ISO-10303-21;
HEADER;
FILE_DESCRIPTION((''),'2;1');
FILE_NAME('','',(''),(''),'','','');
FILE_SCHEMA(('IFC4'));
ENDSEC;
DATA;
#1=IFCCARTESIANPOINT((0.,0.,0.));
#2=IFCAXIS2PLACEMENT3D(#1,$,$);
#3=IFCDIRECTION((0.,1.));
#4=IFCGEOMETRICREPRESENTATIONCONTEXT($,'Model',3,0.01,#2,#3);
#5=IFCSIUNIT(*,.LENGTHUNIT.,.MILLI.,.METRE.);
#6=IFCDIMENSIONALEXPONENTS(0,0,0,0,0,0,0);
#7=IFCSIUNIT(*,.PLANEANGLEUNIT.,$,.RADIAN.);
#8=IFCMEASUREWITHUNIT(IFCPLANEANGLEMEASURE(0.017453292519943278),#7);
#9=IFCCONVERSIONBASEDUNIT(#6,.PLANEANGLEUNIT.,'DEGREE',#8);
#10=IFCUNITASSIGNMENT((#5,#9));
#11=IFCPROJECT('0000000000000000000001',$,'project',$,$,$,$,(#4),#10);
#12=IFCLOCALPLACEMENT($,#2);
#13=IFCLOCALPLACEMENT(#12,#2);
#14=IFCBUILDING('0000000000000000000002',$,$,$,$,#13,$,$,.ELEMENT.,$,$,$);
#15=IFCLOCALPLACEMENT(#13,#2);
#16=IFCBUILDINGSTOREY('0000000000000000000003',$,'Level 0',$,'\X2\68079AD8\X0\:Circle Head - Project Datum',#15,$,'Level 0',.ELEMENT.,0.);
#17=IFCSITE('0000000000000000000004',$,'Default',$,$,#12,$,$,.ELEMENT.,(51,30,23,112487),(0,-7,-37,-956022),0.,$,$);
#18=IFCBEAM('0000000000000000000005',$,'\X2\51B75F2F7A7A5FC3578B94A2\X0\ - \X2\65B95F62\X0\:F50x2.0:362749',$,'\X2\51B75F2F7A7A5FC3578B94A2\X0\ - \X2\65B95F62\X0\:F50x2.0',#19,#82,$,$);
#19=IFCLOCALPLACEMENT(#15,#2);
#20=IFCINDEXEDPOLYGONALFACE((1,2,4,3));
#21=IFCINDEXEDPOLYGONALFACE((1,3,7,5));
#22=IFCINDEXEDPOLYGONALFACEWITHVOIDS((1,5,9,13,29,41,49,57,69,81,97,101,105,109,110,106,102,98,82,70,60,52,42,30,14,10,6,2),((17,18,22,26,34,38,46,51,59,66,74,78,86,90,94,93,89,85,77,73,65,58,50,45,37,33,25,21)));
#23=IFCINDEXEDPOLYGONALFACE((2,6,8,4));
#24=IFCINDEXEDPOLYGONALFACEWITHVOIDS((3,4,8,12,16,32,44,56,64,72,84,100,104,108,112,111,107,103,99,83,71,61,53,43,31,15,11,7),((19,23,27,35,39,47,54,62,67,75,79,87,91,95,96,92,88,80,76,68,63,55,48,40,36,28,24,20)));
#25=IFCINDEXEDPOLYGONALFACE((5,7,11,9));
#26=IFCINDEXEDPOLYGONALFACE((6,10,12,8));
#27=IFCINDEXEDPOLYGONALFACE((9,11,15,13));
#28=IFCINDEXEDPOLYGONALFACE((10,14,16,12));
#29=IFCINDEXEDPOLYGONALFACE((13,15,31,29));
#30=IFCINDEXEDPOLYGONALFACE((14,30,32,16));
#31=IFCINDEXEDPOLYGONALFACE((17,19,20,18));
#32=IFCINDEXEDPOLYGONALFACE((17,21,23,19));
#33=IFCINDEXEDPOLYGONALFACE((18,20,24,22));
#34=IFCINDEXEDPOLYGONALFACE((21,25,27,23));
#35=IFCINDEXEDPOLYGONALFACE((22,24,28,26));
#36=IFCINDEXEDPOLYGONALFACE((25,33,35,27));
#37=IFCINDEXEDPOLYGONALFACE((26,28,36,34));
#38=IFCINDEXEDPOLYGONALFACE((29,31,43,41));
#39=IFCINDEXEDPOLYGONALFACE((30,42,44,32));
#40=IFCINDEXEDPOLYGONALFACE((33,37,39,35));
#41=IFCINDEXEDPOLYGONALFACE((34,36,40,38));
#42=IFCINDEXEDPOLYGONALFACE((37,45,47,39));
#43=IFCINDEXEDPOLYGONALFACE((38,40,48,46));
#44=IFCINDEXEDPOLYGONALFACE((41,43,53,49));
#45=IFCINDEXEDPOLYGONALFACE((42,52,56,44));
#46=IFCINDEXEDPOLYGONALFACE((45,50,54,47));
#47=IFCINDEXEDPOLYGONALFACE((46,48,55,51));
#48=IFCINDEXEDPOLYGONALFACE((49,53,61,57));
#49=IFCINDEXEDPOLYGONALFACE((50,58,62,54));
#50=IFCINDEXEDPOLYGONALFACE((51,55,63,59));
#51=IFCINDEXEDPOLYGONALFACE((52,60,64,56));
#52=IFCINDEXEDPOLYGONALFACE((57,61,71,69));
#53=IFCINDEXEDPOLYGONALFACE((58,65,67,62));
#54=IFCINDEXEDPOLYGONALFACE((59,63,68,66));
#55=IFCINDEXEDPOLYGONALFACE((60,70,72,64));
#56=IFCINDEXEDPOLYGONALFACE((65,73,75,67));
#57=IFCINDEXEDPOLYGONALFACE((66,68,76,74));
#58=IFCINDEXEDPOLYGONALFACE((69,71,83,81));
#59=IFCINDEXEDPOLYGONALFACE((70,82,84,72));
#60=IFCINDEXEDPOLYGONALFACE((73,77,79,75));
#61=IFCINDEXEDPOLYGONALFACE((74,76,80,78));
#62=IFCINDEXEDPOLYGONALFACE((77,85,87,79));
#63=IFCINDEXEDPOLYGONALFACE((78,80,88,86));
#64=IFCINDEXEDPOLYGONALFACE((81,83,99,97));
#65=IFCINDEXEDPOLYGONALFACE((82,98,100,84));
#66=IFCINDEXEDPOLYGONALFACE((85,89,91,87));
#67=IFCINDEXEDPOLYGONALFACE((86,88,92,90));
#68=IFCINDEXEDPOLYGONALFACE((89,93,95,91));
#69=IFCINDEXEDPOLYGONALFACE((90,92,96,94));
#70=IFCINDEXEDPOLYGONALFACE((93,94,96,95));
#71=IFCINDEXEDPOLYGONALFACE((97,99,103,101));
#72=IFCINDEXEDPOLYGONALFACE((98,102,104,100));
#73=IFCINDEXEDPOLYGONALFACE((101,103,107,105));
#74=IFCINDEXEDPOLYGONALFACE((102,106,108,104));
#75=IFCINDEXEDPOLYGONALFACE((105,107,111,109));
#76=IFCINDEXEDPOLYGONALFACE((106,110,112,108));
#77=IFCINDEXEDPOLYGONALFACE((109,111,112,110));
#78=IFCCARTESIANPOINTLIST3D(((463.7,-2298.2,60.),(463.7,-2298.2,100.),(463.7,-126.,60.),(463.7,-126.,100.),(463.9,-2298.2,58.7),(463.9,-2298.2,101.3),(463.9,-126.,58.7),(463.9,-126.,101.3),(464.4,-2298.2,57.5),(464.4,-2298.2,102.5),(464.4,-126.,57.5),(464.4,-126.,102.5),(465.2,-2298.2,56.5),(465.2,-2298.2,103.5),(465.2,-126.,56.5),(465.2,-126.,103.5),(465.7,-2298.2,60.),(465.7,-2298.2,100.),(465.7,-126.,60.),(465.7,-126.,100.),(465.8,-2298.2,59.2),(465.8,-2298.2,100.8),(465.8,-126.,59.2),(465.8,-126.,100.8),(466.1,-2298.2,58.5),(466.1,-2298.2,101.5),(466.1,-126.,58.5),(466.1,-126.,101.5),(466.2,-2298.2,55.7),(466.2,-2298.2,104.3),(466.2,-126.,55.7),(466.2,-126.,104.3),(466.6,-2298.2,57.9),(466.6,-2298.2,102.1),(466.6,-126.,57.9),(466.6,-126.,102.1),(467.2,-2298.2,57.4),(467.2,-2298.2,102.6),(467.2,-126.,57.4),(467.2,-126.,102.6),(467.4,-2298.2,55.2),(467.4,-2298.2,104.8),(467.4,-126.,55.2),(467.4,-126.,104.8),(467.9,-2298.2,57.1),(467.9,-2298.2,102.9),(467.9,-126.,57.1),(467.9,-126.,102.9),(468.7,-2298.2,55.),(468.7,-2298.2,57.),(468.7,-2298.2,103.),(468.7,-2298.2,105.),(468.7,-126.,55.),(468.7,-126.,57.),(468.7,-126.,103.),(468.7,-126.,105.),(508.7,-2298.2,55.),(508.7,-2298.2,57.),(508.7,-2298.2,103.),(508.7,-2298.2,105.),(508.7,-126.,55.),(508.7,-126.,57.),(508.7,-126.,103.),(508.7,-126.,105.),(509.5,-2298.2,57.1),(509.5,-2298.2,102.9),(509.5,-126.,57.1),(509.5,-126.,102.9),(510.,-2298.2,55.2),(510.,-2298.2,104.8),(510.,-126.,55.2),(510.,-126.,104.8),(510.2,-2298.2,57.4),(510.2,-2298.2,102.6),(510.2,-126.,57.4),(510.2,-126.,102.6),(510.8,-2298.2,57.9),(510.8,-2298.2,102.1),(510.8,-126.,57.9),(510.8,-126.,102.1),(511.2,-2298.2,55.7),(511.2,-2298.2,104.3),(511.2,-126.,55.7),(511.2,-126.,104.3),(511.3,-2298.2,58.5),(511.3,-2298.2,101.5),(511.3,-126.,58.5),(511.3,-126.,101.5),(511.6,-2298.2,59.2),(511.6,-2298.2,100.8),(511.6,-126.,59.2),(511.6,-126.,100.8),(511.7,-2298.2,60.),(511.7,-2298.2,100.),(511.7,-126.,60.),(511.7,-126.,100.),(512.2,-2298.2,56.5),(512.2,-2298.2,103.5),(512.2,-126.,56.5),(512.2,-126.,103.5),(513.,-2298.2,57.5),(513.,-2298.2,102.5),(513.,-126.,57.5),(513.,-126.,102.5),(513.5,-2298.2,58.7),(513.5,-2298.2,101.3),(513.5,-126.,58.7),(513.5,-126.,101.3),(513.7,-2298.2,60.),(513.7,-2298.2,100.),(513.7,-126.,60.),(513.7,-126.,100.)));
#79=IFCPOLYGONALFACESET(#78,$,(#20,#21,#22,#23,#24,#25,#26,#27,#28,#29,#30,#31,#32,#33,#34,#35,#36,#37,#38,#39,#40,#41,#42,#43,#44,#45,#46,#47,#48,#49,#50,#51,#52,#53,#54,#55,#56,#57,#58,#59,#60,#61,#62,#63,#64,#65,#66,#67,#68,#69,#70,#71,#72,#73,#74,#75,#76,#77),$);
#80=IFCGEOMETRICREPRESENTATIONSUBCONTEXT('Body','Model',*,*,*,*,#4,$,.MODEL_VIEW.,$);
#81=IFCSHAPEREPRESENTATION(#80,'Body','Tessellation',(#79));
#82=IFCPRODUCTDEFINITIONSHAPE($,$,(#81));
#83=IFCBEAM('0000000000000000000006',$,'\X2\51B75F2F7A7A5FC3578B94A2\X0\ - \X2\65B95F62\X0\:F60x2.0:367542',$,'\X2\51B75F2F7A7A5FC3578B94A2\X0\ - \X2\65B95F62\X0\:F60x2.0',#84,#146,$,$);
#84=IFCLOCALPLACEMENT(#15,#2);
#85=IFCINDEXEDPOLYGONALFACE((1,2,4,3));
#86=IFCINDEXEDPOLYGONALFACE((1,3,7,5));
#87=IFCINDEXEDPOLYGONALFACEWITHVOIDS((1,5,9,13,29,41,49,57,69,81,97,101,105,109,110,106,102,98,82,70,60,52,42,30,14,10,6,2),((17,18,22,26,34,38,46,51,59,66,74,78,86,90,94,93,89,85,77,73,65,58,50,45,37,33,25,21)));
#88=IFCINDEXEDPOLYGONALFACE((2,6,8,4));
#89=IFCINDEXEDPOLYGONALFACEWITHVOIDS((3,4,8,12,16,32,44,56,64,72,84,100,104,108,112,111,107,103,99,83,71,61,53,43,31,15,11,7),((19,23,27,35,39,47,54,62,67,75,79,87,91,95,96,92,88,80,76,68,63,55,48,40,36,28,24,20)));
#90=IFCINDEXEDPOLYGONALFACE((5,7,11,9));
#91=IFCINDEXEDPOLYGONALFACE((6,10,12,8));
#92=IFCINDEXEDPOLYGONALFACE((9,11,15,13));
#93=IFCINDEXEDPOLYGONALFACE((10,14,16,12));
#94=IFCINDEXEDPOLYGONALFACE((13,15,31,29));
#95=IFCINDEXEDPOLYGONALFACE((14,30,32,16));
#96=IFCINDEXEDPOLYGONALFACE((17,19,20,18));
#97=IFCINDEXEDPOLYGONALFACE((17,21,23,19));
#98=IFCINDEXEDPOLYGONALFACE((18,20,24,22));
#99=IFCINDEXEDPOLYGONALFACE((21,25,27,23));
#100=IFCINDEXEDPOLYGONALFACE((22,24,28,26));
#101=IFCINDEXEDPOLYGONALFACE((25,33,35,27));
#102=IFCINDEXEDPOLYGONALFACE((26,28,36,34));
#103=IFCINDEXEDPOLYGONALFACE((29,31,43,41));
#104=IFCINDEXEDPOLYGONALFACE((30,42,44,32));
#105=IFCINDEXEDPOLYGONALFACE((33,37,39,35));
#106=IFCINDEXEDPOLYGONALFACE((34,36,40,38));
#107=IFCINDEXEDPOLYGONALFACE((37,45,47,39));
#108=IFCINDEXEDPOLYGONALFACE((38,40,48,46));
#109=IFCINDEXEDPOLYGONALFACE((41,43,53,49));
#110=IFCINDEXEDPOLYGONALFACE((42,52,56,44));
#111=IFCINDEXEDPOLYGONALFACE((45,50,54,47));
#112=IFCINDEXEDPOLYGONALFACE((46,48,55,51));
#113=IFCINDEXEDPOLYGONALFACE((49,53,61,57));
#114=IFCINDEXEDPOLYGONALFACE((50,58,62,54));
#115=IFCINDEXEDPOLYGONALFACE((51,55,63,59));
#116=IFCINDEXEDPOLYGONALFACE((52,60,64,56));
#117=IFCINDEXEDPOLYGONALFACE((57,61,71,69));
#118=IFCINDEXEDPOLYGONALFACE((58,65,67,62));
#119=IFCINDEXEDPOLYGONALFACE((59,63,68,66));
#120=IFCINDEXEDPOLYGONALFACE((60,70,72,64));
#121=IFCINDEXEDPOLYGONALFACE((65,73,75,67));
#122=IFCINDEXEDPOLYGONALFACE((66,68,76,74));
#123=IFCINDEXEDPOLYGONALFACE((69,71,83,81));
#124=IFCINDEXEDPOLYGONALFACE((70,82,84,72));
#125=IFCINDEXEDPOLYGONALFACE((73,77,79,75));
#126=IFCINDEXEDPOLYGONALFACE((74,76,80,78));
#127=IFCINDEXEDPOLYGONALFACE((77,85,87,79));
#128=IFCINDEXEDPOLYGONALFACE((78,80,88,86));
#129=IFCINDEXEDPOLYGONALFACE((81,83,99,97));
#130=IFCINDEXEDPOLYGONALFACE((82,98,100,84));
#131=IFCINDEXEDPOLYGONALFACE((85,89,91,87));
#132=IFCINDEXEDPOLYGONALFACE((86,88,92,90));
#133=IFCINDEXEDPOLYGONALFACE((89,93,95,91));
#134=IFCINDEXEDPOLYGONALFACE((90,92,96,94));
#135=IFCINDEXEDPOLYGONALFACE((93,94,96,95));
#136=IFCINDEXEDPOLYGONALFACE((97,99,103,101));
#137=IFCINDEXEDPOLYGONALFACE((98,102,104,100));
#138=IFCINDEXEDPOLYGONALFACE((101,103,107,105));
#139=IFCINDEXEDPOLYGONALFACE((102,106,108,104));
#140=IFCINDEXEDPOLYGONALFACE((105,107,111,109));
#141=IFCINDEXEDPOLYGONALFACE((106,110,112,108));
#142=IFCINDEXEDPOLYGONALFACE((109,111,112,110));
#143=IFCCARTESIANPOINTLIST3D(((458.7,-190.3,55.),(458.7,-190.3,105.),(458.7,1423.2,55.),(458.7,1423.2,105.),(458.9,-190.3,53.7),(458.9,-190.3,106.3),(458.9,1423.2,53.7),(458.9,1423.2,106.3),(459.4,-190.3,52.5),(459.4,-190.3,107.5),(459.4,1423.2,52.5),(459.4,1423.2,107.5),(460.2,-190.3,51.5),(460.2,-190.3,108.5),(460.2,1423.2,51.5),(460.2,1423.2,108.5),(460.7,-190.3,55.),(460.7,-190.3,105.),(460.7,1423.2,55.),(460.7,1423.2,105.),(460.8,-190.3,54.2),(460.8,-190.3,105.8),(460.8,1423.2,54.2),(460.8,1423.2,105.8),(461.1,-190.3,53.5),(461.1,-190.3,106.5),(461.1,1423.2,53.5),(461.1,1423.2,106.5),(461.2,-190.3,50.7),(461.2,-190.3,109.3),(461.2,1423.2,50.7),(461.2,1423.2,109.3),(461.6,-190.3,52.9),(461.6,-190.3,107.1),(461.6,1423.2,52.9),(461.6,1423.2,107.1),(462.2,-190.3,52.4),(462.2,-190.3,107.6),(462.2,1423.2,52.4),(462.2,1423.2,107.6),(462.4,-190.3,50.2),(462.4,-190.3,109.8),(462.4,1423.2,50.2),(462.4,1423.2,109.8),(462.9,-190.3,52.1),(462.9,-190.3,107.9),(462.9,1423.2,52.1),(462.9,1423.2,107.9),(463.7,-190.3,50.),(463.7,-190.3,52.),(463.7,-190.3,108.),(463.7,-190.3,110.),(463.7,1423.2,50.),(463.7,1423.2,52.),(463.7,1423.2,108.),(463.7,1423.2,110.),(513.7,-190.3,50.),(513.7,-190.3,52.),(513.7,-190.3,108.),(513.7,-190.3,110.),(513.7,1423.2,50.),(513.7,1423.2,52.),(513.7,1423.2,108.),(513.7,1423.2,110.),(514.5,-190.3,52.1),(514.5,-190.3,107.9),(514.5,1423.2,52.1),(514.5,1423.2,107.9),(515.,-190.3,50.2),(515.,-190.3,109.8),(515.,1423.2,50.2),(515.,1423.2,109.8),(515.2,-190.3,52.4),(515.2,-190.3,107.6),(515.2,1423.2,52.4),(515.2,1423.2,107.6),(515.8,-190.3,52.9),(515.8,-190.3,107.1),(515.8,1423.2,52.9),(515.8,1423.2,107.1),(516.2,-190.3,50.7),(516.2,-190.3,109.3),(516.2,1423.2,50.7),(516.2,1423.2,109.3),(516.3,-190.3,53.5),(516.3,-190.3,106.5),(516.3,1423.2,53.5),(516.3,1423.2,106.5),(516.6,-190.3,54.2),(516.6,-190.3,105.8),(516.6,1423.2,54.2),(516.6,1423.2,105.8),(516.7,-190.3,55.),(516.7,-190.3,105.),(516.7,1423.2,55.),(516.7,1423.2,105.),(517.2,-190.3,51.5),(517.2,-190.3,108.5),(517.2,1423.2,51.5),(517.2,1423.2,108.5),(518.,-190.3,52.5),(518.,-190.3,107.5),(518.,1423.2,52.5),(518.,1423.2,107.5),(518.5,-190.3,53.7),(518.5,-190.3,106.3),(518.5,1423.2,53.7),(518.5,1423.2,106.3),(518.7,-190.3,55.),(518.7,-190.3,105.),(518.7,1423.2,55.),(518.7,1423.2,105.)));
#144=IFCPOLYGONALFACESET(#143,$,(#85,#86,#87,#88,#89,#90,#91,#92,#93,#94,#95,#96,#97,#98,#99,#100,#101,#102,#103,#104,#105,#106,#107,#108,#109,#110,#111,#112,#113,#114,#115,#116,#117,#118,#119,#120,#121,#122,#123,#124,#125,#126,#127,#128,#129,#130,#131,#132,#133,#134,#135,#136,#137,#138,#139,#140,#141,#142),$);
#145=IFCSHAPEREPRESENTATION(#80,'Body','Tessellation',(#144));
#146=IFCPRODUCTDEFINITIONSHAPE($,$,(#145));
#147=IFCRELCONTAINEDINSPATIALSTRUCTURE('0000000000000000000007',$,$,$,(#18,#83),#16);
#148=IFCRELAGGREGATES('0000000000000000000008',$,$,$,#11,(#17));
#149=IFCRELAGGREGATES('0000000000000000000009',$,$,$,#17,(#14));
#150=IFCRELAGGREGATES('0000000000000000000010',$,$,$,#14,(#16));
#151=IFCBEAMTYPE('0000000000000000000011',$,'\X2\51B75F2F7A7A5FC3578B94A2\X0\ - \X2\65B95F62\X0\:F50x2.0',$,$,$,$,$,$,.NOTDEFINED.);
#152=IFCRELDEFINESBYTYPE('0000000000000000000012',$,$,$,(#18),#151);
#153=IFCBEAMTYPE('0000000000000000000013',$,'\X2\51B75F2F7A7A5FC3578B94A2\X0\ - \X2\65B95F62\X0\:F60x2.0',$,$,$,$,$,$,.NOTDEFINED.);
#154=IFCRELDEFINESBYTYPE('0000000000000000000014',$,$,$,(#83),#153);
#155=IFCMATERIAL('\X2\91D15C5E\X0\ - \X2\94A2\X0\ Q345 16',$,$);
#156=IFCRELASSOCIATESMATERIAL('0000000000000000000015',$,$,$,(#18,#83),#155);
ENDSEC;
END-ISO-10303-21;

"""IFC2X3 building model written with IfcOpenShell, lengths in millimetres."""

from ifc_helpers import new_model, entity, si_unit, converted_unit, direction, frame, frame_2d, origin, place, context, subcontext, project, spatial, polyline, circle_curve, parameter, trimmed, segment, composite_curve, outline, extrude, material, type_object, element, save


model = new_model("IFC2X3")

# Units and contexts
model_context = context("Model", 3, precision=0.01, world=origin(), true_north=direction((0.0, 1.0)))
body_context = subcontext(model_context, "Body", "Model", "MODEL_VIEW")
ifc_project = project(units=[si_unit("LENGTHUNIT", "METRE", prefix="MILLI"), converted_unit("PLANEANGLEUNIT", "DEGREE", entity("IfcPlaneAngleMeasure", 0.017453292519943278), si_unit("PLANEANGLEUNIT", "RADIAN"), dimensions=[0, 0, 0, 0, 0, 0, 0])], contexts=[model_context])

# Site, building, storey
site_placement = place(None, origin())
site = spatial("IfcSite", under=ifc_project, at=site_placement, Name="Default", CompositionType="ELEMENT", RefLatitude=(51, 30, 23, 112487), RefLongitude=(0, -7, -37, -956022), RefElevation=0.0)
building_placement = place(site_placement, origin())
building = spatial("IfcBuilding", under=site, at=building_placement, CompositionType="ELEMENT")
storey_placement = place(building_placement, origin())
storey = spatial("IfcBuildingStorey", under=building, at=storey_placement, Name="Level 0", ObjectType="标高:Circle Head - Project Datum", LongName="Level 0", CompositionType="ELEMENT", Elevation=0.0)

# Beams
ifc_material_1 = material(Name="金属 - 钢 Q345 16")
beam_type_1 = type_object("IfcBeamType", Name="冷弯空心型钢 - 方形:F50x2.0", PredefinedType="NOTDEFINED")
beam_1_placement = place(storey_placement, frame((488.7, -390.5, 105.0), z_axis=(0.0, 0.0, 1.0), x_axis=(0.0, -1.0, 0.0)))
element("IfcBeam", 1, at=beam_1_placement, inside=storey, type_object=beam_type_1, material=ifc_material_1, Name="冷弯空心型钢 - 方形:F50x2.0:362749", ObjectType="冷弯空心型钢 - 方形:F50x2.0", context=body_context, shape_type="SweptSolid", body=[
    extrude(outline(composite_curve([segment(trimmed(circle_curve(frame_2d((-20.0, 20.0), x_axis=(1.0, 0.0)), 5.0), [parameter(90.0)], [parameter(180.0)], True, "PARAMETER"), True, "CONTINUOUS"), segment(polyline([(-25.0, 20.0), (-25.0, -20.0)]), True, "CONTINUOUS"), segment(trimmed(circle_curve(frame_2d((-20.0, -20.0), x_axis=(1.0, 0.0)), 5.0), [parameter(180.0)], [parameter(270.0)], True, "PARAMETER"), True, "CONTINUOUS"), segment(polyline([(-20.0, -25.0), (20.0, -25.0)]), True, "CONTINUOUS"), segment(trimmed(circle_curve(frame_2d((20.0, -20.0), x_axis=(1.0, 0.0)), 5.0), [parameter(270.0)], [parameter(0.0)], True, "PARAMETER"), True, "CONTINUOUS"), segment(polyline([(25.0, -20.0), (25.0, 20.0)]), True, "CONTINUOUS"), segment(trimmed(circle_curve(frame_2d((20.0, 20.0), x_axis=(1.0, 0.0)), 5.0), [parameter(0.0)], [parameter(90.0)], True, "PARAMETER"), True, "CONTINUOUS"), segment(polyline([(20.0, 25.0), (-20.0, 25.0)]), True, "CONTINUOUS")], self_intersect=False), holes=[composite_curve([segment(polyline([(-20.0, 23.0), (20.0, 23.0)]), True, "CONTINUOUS"), segment(trimmed(circle_curve(frame_2d((20.0, 20.0), x_axis=(1.0, 0.0)), 3.0), [parameter(360.0)], [parameter(90.0)], True, "PARAMETER"), False, "CONTINUOUS"), segment(polyline([(23.0, 20.0), (23.0, -20.0)]), True, "CONTINUOUS"), segment(trimmed(circle_curve(frame_2d((20.0, -20.0), x_axis=(1.0, 0.0)), 3.0), [parameter(270.0)], [parameter(360.0)], True, "PARAMETER"), False, "CONTINUOUS"), segment(polyline([(20.0, -23.0), (-20.0, -23.0)]), True, "CONTINUOUS"), segment(trimmed(circle_curve(frame_2d((-20.0, -20.0), x_axis=(1.0, 0.0)), 3.0), [parameter(180.0)], [parameter(270.0)], True, "PARAMETER"), False, "CONTINUOUS"), segment(polyline([(-23.0, -20.0), (-23.0, 20.0)]), True, "CONTINUOUS"), segment(trimmed(circle_curve(frame_2d((-20.0, 20.0), x_axis=(1.0, 0.0)), 3.0), [parameter(90.0)], [parameter(180.0)], True, "PARAMETER"), False, "CONTINUOUS")], self_intersect=False)]), frame((-264.5, 0.0, -25.0), z_axis=(1.0, 0.0, 0.0), x_axis=(0.0, 1.0, 0.0)), (0.0, 0.0, 1.0), 2172.2),
])
beam_type_2 = type_object("IfcBeamType", Name="冷弯空心型钢 - 方形:F60x2.0", PredefinedType="NOTDEFINED")
beam_2_placement = place(storey_placement, frame((488.7, 1388.1, 110.0), z_axis=(0.0, 0.0, 1.0), x_axis=(0.0, -1.0, 0.0)))
element("IfcBeam", 2, at=beam_2_placement, inside=storey, type_object=beam_type_2, material=ifc_material_1, Name="冷弯空心型钢 - 方形:F60x2.0:367542", ObjectType="冷弯空心型钢 - 方形:F60x2.0", context=body_context, shape_type="SweptSolid", body=[
    extrude(outline(composite_curve([segment(trimmed(circle_curve(frame_2d((-25.0, 25.0), x_axis=(1.0, 0.0)), 5.0), [parameter(90.0)], [parameter(180.0)], True, "PARAMETER"), True, "CONTINUOUS"), segment(polyline([(-30.0, 25.0), (-30.0, -25.0)]), True, "CONTINUOUS"), segment(trimmed(circle_curve(frame_2d((-25.0, -25.0), x_axis=(1.0, 0.0)), 5.0), [parameter(180.0)], [parameter(270.0)], True, "PARAMETER"), True, "CONTINUOUS"), segment(polyline([(-25.0, -30.0), (25.0, -30.0)]), True, "CONTINUOUS"), segment(trimmed(circle_curve(frame_2d((25.0, -25.0), x_axis=(1.0, 0.0)), 5.0), [parameter(270.0)], [parameter(0.0)], True, "PARAMETER"), True, "CONTINUOUS"), segment(polyline([(30.0, -25.0), (30.0, 25.0)]), True, "CONTINUOUS"), segment(trimmed(circle_curve(frame_2d((25.0, 25.0), x_axis=(1.0, 0.0)), 5.0), [parameter(0.0)], [parameter(90.0)], True, "PARAMETER"), True, "CONTINUOUS"), segment(polyline([(25.0, 30.0), (-25.0, 30.0)]), True, "CONTINUOUS")], self_intersect=False), holes=[composite_curve([segment(polyline([(-25.0, 28.0), (25.0, 28.0)]), True, "CONTINUOUS"), segment(trimmed(circle_curve(frame_2d((25.0, 25.0), x_axis=(1.0, 0.0)), 3.0), [parameter(0.0)], [parameter(90.0)], True, "PARAMETER"), False, "CONTINUOUS"), segment(polyline([(28.0, 25.0), (28.0, -25.0)]), True, "CONTINUOUS"), segment(trimmed(circle_curve(frame_2d((25.0, -25.0), x_axis=(1.0, 0.0)), 3.0), [parameter(270.0)], [parameter(360.0)], True, "PARAMETER"), False, "CONTINUOUS"), segment(polyline([(25.0, -28.0), (-25.0, -28.0)]), True, "CONTINUOUS"), segment(trimmed(circle_curve(frame_2d((-25.0, -25.0), x_axis=(1.0, 0.0)), 3.0), [parameter(180.0)], [parameter(270.0)], True, "PARAMETER"), False, "CONTINUOUS"), segment(polyline([(-28.0, -25.0), (-28.0, 25.0)]), True, "CONTINUOUS"), segment(trimmed(circle_curve(frame_2d((-25.0, 25.0), x_axis=(1.0, 0.0)), 3.0), [parameter(90.0)], [parameter(180.0)], True, "PARAMETER"), False, "CONTINUOUS")], self_intersect=False)]), frame((-35.1, 0.0, -30.0), z_axis=(1.0, 0.0, 0.0), x_axis=(0.0, 1.0, 0.0)), (0.0, 0.0, 1.0), 1613.5),
])

save(model, "model.ifc")
